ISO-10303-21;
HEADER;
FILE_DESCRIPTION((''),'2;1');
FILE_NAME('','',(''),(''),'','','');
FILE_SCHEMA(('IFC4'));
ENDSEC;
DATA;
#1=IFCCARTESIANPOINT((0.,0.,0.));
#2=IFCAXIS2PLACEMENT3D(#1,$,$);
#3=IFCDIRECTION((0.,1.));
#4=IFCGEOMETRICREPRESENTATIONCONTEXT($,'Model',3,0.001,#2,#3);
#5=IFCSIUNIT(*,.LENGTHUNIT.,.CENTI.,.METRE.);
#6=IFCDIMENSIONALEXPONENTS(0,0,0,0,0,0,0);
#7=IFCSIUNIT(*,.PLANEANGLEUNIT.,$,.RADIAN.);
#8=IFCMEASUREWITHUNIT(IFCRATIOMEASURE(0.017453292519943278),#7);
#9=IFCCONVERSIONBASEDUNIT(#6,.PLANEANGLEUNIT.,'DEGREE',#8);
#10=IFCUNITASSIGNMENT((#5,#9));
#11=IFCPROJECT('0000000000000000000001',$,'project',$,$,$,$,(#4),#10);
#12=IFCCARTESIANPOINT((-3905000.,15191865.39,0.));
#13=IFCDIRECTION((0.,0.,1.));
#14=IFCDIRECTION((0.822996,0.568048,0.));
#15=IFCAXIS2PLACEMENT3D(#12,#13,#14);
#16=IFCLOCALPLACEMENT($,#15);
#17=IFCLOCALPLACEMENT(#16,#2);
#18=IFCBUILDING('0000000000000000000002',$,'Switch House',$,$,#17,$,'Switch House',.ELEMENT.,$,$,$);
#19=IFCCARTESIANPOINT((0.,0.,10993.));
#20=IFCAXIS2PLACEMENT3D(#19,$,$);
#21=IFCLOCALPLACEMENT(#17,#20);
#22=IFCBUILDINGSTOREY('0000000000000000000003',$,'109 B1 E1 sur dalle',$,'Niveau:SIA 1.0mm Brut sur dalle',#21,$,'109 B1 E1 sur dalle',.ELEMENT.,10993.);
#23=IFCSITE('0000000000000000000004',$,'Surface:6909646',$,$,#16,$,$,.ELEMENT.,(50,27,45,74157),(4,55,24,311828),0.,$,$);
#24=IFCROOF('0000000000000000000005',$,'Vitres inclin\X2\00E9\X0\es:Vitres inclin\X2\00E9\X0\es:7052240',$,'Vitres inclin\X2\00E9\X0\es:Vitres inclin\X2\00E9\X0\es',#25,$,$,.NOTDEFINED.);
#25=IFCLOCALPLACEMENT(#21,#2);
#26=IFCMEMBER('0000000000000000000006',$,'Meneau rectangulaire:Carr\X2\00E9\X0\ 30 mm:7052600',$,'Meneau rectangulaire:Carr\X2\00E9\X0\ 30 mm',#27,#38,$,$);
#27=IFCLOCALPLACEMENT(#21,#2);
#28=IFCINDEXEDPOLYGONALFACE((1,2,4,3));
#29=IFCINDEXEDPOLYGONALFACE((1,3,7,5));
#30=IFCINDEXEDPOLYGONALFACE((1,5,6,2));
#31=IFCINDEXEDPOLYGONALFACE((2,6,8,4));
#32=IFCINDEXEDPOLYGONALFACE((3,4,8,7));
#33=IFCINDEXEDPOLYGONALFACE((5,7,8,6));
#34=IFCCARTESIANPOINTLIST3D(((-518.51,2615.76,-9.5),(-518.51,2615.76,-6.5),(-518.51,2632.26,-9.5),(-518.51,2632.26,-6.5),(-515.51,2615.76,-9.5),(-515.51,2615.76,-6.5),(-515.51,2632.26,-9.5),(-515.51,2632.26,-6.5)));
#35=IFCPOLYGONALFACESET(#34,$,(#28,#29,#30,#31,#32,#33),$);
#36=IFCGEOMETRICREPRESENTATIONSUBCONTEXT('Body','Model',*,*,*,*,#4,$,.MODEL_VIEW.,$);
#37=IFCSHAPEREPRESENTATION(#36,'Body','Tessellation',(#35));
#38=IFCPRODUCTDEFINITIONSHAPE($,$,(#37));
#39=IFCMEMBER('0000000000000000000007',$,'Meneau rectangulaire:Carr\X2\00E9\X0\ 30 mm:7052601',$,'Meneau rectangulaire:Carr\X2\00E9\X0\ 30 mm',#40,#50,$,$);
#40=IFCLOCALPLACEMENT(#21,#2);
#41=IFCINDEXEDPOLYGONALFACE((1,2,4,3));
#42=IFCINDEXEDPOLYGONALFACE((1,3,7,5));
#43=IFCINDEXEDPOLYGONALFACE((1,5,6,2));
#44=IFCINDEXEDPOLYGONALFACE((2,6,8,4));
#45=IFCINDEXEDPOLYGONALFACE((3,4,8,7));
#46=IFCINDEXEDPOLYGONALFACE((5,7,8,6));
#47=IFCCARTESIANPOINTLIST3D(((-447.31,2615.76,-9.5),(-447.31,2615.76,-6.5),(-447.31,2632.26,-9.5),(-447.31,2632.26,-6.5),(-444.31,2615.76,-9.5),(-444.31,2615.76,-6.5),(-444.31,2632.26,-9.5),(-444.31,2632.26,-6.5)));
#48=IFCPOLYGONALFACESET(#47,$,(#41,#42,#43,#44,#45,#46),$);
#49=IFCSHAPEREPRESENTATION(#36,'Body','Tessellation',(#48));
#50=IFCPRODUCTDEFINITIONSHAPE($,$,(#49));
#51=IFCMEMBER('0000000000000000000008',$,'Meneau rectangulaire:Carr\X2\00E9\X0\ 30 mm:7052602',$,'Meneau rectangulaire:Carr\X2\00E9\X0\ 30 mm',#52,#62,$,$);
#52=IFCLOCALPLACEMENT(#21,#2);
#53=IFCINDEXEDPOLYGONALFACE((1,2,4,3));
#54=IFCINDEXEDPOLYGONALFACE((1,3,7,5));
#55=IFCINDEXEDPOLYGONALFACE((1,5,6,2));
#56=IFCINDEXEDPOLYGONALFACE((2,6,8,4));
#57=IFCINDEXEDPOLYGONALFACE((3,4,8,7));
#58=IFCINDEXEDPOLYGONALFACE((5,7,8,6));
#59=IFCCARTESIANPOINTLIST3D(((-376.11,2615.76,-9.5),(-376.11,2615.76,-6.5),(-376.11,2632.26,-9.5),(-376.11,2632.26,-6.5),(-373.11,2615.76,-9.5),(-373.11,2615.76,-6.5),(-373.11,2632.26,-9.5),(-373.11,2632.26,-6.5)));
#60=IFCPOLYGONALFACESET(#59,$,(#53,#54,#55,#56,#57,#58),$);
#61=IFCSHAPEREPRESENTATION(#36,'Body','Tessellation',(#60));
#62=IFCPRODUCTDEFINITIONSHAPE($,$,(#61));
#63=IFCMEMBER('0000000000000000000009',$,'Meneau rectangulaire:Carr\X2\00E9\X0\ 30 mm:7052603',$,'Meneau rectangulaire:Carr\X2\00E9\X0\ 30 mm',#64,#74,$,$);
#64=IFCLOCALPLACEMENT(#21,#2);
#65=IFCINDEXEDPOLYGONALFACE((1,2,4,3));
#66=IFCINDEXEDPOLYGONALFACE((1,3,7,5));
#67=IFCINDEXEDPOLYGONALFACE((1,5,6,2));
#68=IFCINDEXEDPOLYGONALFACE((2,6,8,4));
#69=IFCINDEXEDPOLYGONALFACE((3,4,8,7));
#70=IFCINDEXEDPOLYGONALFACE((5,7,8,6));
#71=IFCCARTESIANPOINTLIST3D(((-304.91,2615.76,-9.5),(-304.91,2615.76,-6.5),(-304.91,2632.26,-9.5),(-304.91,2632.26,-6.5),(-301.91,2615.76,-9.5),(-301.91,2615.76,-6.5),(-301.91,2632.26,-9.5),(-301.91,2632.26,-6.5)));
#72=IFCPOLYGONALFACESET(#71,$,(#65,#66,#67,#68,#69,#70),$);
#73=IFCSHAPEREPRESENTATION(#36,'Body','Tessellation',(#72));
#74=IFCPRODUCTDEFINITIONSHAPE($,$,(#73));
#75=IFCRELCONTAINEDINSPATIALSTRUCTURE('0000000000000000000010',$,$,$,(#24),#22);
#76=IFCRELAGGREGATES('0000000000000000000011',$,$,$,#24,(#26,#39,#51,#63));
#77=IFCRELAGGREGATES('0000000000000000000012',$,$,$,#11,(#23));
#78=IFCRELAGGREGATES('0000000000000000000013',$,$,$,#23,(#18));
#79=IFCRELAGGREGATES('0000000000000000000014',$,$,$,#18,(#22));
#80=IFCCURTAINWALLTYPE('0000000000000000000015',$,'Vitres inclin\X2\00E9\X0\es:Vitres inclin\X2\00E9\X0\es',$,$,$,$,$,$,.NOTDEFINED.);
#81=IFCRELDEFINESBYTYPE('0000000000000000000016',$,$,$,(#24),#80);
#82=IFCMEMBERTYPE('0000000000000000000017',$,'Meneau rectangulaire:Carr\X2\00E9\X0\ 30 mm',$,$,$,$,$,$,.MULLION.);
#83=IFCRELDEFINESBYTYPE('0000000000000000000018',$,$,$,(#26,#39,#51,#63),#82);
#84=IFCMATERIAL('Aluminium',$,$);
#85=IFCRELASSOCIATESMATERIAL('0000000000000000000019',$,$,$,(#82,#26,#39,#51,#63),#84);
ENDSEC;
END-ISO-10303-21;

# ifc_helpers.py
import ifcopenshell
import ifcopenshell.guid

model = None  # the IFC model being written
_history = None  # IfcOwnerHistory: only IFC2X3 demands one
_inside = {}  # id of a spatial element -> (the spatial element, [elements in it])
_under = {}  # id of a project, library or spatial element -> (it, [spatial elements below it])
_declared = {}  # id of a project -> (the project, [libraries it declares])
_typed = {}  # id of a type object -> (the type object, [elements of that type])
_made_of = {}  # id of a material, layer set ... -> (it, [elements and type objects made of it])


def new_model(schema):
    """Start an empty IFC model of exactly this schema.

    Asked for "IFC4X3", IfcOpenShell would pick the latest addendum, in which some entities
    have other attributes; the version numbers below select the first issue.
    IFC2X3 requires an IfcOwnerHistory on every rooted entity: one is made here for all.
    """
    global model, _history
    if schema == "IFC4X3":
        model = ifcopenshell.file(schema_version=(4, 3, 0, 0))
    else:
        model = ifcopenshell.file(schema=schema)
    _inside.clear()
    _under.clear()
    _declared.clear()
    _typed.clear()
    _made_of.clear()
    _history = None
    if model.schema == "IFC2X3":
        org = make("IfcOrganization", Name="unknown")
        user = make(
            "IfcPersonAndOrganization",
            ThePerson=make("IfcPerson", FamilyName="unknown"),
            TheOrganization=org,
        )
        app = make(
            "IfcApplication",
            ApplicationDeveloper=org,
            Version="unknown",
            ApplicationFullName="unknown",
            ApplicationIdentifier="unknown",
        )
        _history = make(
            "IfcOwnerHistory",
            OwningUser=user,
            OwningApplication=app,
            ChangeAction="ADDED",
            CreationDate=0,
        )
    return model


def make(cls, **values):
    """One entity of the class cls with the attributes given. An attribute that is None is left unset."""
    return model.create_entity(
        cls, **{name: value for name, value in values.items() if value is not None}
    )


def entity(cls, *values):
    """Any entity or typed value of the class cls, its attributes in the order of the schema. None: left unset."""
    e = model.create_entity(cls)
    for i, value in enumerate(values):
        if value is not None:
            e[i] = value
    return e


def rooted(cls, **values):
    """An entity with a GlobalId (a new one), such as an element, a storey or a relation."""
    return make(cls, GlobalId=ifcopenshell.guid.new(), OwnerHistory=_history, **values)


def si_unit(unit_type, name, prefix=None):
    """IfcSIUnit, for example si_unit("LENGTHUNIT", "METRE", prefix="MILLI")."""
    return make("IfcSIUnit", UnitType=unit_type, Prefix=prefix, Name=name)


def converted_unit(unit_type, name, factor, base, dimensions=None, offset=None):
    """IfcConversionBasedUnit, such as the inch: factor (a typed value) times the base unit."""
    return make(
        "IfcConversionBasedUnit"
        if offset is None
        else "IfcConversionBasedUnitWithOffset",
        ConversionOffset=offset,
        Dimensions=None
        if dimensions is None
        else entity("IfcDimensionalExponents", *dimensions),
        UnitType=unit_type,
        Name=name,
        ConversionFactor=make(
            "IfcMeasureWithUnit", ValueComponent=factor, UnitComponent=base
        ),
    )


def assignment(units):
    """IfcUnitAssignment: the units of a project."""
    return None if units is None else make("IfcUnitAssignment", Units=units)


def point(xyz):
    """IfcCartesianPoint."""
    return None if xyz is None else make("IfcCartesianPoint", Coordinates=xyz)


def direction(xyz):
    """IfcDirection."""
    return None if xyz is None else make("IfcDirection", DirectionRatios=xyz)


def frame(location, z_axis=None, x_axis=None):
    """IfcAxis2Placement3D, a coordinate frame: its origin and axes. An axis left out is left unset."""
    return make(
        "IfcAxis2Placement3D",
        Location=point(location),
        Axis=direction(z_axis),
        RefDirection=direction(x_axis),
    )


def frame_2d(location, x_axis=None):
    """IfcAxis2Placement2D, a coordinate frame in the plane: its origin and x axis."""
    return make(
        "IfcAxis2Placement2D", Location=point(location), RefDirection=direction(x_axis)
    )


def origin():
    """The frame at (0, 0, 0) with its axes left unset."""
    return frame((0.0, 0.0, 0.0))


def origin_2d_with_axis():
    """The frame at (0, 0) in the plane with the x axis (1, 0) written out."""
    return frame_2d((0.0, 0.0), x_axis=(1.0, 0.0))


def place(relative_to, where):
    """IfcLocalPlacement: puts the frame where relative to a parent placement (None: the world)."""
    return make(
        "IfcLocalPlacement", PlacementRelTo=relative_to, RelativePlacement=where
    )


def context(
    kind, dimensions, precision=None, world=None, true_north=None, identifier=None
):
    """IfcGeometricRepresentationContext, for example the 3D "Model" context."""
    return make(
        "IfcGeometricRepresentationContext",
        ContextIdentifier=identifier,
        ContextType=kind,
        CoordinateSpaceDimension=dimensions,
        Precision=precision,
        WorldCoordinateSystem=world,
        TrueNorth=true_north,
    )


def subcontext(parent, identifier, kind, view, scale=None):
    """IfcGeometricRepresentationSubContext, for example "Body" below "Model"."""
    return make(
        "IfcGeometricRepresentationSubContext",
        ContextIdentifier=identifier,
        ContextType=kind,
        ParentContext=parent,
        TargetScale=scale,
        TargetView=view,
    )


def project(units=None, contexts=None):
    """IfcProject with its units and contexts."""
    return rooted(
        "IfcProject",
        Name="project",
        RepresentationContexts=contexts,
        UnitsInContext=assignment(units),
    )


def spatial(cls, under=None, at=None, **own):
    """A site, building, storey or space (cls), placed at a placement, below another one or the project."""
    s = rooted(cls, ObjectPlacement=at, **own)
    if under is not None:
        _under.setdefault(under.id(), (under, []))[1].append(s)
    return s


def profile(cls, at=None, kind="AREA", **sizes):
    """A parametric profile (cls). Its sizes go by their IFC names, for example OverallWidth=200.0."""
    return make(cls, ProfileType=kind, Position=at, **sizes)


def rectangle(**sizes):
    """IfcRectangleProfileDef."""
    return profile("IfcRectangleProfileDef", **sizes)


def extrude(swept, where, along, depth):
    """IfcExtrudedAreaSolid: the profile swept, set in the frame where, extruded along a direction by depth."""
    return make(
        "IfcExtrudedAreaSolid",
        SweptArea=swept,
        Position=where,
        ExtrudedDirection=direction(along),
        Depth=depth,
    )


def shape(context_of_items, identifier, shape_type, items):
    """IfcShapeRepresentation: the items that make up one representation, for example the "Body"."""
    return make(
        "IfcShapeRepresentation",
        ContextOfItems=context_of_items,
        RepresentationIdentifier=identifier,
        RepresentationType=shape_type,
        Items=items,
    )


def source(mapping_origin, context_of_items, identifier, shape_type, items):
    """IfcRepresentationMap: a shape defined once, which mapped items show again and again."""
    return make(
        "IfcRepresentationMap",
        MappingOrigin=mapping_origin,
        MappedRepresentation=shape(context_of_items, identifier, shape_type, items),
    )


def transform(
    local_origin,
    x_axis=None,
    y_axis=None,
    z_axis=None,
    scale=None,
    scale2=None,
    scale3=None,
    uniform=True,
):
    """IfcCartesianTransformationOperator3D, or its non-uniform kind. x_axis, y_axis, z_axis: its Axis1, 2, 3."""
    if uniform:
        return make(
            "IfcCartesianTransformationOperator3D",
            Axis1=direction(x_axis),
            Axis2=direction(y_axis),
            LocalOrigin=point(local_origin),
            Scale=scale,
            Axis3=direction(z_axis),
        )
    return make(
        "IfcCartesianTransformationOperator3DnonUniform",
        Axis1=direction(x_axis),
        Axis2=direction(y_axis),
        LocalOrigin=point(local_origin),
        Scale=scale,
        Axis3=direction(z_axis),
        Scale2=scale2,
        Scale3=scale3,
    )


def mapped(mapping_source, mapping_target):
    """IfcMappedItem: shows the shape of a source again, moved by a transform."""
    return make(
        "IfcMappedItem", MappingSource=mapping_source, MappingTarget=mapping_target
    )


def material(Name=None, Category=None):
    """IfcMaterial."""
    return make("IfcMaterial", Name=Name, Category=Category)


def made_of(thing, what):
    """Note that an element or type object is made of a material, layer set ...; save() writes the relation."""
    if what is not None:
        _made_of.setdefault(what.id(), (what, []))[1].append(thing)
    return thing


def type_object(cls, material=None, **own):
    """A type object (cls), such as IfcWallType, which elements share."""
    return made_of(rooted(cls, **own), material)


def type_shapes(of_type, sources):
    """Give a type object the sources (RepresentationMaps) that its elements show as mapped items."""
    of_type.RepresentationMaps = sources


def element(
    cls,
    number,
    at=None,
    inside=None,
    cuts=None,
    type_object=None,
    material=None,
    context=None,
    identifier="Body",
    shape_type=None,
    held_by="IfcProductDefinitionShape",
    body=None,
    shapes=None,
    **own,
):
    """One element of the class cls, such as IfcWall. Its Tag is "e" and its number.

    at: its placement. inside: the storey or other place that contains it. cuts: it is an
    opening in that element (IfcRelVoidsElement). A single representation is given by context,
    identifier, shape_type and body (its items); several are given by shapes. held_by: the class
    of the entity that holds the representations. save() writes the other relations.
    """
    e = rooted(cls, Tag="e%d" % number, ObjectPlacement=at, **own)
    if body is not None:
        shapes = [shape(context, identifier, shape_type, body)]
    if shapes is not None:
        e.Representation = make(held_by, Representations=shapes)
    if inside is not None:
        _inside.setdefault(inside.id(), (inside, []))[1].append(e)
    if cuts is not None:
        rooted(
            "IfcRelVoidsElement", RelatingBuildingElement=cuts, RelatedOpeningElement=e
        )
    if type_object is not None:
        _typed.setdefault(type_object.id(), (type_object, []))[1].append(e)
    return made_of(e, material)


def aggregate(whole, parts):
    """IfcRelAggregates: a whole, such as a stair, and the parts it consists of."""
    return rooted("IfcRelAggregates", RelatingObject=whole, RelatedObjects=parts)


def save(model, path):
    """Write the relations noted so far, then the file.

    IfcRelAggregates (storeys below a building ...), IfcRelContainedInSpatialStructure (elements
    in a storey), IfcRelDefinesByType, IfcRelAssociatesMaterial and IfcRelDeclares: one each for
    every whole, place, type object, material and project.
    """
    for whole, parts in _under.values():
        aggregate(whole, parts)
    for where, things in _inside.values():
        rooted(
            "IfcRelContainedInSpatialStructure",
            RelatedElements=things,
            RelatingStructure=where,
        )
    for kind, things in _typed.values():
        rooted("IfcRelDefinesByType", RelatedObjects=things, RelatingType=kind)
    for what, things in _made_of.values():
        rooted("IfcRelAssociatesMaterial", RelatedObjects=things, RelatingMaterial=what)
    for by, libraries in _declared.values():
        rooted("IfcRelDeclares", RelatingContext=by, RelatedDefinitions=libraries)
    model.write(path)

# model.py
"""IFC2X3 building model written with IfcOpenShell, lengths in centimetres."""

from ifc_helpers import new_model, entity, si_unit, converted_unit, direction, frame, origin, origin_2d_with_axis, place, context, subcontext, project, spatial, rectangle, extrude, source, transform, mapped, material, type_object, type_shapes, element, aggregate, save


model = new_model("IFC2X3")

# Units and contexts
model_context = context("Model", 3, precision=0.001, world=origin(), true_north=direction((0.0, 1.0)))
body_context = subcontext(model_context, "Body", "Model", "MODEL_VIEW")
ifc_project = project(units=[si_unit("LENGTHUNIT", "METRE", prefix="CENTI"), converted_unit("PLANEANGLEUNIT", "DEGREE", entity("IfcRatioMeasure", 0.017453292519943278), si_unit("PLANEANGLEUNIT", "RADIAN"), dimensions=[0, 0, 0, 0, 0, 0, 0])], contexts=[model_context])

# Site, building, storey
site_placement = place(None, frame((-3905000.0, 15191865.39, 0.0), z_axis=(0.0, 0.0, 1.0), x_axis=(0.822996, 0.568048, 0.0)))
site = spatial("IfcSite", under=ifc_project, at=site_placement, Name="Surface:6909646", CompositionType="ELEMENT", RefLatitude=(50, 27, 45, 74157), RefLongitude=(4, 55, 24, 311828), RefElevation=0.0)
building_placement = place(site_placement, origin())
building = spatial("IfcBuilding", under=site, at=building_placement, Name="Switch House", LongName="Switch House", CompositionType="ELEMENT")
storey_placement = place(building_placement, frame((0.0, 0.0, 10993.0)))
storey = spatial("IfcBuildingStorey", under=building, at=storey_placement, Name="109 B1 E1 sur dalle", ObjectType="Niveau:SIA 1.0mm Brut sur dalle", LongName="109 B1 E1 sur dalle", CompositionType="ELEMENT", Elevation=10993.0)

# Roof, members
curtain_wall_type = type_object("IfcCurtainWallType", Name="Vitres inclinées:Vitres inclinées", PredefinedType="NOTDEFINED")
roof_placement = place(storey_placement, frame((0.0, 0.0, -10993.0)))
roof = element("IfcRoof", 1, at=roof_placement, inside=storey, type_object=curtain_wall_type, Name="Vitres inclinées:Vitres inclinées:7052240", ObjectType="Vitres inclinées:Vitres inclinées", ShapeType="NOTDEFINED")
ifc_material = material(Name="Aluminium")
member_type_1 = type_object("IfcMemberType", Name="Meneau rectangulaire:Carré 30 mm", PredefinedType="MULLION", material=ifc_material)
shared_shape_1 = source(origin(), body_context, "Body", "SweptSolid", [
    extrude(rectangle(XDim=3.0, YDim=3.0, at=origin_2d_with_axis()), frame((0.0, 0.0, -16.5), z_axis=(0.0, 0.0, 1.0), x_axis=(0.0, -1.0, 0.0)), (0.0, 0.0, 1.0), 16.5),
])
type_shapes(member_type_1, [shared_shape_1])
member_1_placement = place(roof_placement, frame((-517.01, 2632.26, 10985.0), z_axis=(0.0, 1.0, 0.0), x_axis=(1.0, 0.0, 0.0)))
member_1 = element("IfcMember", 2, at=member_1_placement, type_object=member_type_1, material=ifc_material, Name="Meneau rectangulaire:Carré 30 mm:7052600", ObjectType="Meneau rectangulaire:Carré 30 mm", context=body_context, shape_type="MappedRepresentation", body=[
    mapped(shared_shape_1, transform((0.0, 0.0, 0.0), scale=1.0)),
])
member_2_placement = place(roof_placement, frame((-445.81, 2632.26, 10985.0), z_axis=(0.0, 1.0, 0.0), x_axis=(1.0, 0.0, 0.0)))
member_2 = element("IfcMember", 3, at=member_2_placement, type_object=member_type_1, material=ifc_material, Name="Meneau rectangulaire:Carré 30 mm:7052601", ObjectType="Meneau rectangulaire:Carré 30 mm", context=body_context, shape_type="MappedRepresentation", body=[
    mapped(shared_shape_1, transform((0.0, 0.0, 0.0), scale=1.0)),
])
member_3_placement = place(roof_placement, frame((-374.61, 2632.26, 10985.0), z_axis=(0.0, 1.0, 0.0), x_axis=(1.0, 0.0, 0.0)))
member_3 = element("IfcMember", 4, at=member_3_placement, type_object=member_type_1, material=ifc_material, Name="Meneau rectangulaire:Carré 30 mm:7052602", ObjectType="Meneau rectangulaire:Carré 30 mm", context=body_context, shape_type="MappedRepresentation", body=[
    mapped(shared_shape_1, transform((0.0, 0.0, 0.0), scale=1.0)),
])
member_4_placement = place(roof_placement, frame((-303.41, 2632.26, 10985.0), z_axis=(0.0, 1.0, 0.0), x_axis=(1.0, 0.0, 0.0)))
member_4 = element("IfcMember", 5, at=member_4_placement, type_object=member_type_1, material=ifc_material, Name="Meneau rectangulaire:Carré 30 mm:7052603", ObjectType="Meneau rectangulaire:Carré 30 mm", context=body_context, shape_type="MappedRepresentation", body=[
    mapped(shared_shape_1, transform((0.0, 0.0, 0.0), scale=1.0)),
])
aggregate(roof, [member_1, member_2, member_3, member_4])

save(model, "model.ifc")
